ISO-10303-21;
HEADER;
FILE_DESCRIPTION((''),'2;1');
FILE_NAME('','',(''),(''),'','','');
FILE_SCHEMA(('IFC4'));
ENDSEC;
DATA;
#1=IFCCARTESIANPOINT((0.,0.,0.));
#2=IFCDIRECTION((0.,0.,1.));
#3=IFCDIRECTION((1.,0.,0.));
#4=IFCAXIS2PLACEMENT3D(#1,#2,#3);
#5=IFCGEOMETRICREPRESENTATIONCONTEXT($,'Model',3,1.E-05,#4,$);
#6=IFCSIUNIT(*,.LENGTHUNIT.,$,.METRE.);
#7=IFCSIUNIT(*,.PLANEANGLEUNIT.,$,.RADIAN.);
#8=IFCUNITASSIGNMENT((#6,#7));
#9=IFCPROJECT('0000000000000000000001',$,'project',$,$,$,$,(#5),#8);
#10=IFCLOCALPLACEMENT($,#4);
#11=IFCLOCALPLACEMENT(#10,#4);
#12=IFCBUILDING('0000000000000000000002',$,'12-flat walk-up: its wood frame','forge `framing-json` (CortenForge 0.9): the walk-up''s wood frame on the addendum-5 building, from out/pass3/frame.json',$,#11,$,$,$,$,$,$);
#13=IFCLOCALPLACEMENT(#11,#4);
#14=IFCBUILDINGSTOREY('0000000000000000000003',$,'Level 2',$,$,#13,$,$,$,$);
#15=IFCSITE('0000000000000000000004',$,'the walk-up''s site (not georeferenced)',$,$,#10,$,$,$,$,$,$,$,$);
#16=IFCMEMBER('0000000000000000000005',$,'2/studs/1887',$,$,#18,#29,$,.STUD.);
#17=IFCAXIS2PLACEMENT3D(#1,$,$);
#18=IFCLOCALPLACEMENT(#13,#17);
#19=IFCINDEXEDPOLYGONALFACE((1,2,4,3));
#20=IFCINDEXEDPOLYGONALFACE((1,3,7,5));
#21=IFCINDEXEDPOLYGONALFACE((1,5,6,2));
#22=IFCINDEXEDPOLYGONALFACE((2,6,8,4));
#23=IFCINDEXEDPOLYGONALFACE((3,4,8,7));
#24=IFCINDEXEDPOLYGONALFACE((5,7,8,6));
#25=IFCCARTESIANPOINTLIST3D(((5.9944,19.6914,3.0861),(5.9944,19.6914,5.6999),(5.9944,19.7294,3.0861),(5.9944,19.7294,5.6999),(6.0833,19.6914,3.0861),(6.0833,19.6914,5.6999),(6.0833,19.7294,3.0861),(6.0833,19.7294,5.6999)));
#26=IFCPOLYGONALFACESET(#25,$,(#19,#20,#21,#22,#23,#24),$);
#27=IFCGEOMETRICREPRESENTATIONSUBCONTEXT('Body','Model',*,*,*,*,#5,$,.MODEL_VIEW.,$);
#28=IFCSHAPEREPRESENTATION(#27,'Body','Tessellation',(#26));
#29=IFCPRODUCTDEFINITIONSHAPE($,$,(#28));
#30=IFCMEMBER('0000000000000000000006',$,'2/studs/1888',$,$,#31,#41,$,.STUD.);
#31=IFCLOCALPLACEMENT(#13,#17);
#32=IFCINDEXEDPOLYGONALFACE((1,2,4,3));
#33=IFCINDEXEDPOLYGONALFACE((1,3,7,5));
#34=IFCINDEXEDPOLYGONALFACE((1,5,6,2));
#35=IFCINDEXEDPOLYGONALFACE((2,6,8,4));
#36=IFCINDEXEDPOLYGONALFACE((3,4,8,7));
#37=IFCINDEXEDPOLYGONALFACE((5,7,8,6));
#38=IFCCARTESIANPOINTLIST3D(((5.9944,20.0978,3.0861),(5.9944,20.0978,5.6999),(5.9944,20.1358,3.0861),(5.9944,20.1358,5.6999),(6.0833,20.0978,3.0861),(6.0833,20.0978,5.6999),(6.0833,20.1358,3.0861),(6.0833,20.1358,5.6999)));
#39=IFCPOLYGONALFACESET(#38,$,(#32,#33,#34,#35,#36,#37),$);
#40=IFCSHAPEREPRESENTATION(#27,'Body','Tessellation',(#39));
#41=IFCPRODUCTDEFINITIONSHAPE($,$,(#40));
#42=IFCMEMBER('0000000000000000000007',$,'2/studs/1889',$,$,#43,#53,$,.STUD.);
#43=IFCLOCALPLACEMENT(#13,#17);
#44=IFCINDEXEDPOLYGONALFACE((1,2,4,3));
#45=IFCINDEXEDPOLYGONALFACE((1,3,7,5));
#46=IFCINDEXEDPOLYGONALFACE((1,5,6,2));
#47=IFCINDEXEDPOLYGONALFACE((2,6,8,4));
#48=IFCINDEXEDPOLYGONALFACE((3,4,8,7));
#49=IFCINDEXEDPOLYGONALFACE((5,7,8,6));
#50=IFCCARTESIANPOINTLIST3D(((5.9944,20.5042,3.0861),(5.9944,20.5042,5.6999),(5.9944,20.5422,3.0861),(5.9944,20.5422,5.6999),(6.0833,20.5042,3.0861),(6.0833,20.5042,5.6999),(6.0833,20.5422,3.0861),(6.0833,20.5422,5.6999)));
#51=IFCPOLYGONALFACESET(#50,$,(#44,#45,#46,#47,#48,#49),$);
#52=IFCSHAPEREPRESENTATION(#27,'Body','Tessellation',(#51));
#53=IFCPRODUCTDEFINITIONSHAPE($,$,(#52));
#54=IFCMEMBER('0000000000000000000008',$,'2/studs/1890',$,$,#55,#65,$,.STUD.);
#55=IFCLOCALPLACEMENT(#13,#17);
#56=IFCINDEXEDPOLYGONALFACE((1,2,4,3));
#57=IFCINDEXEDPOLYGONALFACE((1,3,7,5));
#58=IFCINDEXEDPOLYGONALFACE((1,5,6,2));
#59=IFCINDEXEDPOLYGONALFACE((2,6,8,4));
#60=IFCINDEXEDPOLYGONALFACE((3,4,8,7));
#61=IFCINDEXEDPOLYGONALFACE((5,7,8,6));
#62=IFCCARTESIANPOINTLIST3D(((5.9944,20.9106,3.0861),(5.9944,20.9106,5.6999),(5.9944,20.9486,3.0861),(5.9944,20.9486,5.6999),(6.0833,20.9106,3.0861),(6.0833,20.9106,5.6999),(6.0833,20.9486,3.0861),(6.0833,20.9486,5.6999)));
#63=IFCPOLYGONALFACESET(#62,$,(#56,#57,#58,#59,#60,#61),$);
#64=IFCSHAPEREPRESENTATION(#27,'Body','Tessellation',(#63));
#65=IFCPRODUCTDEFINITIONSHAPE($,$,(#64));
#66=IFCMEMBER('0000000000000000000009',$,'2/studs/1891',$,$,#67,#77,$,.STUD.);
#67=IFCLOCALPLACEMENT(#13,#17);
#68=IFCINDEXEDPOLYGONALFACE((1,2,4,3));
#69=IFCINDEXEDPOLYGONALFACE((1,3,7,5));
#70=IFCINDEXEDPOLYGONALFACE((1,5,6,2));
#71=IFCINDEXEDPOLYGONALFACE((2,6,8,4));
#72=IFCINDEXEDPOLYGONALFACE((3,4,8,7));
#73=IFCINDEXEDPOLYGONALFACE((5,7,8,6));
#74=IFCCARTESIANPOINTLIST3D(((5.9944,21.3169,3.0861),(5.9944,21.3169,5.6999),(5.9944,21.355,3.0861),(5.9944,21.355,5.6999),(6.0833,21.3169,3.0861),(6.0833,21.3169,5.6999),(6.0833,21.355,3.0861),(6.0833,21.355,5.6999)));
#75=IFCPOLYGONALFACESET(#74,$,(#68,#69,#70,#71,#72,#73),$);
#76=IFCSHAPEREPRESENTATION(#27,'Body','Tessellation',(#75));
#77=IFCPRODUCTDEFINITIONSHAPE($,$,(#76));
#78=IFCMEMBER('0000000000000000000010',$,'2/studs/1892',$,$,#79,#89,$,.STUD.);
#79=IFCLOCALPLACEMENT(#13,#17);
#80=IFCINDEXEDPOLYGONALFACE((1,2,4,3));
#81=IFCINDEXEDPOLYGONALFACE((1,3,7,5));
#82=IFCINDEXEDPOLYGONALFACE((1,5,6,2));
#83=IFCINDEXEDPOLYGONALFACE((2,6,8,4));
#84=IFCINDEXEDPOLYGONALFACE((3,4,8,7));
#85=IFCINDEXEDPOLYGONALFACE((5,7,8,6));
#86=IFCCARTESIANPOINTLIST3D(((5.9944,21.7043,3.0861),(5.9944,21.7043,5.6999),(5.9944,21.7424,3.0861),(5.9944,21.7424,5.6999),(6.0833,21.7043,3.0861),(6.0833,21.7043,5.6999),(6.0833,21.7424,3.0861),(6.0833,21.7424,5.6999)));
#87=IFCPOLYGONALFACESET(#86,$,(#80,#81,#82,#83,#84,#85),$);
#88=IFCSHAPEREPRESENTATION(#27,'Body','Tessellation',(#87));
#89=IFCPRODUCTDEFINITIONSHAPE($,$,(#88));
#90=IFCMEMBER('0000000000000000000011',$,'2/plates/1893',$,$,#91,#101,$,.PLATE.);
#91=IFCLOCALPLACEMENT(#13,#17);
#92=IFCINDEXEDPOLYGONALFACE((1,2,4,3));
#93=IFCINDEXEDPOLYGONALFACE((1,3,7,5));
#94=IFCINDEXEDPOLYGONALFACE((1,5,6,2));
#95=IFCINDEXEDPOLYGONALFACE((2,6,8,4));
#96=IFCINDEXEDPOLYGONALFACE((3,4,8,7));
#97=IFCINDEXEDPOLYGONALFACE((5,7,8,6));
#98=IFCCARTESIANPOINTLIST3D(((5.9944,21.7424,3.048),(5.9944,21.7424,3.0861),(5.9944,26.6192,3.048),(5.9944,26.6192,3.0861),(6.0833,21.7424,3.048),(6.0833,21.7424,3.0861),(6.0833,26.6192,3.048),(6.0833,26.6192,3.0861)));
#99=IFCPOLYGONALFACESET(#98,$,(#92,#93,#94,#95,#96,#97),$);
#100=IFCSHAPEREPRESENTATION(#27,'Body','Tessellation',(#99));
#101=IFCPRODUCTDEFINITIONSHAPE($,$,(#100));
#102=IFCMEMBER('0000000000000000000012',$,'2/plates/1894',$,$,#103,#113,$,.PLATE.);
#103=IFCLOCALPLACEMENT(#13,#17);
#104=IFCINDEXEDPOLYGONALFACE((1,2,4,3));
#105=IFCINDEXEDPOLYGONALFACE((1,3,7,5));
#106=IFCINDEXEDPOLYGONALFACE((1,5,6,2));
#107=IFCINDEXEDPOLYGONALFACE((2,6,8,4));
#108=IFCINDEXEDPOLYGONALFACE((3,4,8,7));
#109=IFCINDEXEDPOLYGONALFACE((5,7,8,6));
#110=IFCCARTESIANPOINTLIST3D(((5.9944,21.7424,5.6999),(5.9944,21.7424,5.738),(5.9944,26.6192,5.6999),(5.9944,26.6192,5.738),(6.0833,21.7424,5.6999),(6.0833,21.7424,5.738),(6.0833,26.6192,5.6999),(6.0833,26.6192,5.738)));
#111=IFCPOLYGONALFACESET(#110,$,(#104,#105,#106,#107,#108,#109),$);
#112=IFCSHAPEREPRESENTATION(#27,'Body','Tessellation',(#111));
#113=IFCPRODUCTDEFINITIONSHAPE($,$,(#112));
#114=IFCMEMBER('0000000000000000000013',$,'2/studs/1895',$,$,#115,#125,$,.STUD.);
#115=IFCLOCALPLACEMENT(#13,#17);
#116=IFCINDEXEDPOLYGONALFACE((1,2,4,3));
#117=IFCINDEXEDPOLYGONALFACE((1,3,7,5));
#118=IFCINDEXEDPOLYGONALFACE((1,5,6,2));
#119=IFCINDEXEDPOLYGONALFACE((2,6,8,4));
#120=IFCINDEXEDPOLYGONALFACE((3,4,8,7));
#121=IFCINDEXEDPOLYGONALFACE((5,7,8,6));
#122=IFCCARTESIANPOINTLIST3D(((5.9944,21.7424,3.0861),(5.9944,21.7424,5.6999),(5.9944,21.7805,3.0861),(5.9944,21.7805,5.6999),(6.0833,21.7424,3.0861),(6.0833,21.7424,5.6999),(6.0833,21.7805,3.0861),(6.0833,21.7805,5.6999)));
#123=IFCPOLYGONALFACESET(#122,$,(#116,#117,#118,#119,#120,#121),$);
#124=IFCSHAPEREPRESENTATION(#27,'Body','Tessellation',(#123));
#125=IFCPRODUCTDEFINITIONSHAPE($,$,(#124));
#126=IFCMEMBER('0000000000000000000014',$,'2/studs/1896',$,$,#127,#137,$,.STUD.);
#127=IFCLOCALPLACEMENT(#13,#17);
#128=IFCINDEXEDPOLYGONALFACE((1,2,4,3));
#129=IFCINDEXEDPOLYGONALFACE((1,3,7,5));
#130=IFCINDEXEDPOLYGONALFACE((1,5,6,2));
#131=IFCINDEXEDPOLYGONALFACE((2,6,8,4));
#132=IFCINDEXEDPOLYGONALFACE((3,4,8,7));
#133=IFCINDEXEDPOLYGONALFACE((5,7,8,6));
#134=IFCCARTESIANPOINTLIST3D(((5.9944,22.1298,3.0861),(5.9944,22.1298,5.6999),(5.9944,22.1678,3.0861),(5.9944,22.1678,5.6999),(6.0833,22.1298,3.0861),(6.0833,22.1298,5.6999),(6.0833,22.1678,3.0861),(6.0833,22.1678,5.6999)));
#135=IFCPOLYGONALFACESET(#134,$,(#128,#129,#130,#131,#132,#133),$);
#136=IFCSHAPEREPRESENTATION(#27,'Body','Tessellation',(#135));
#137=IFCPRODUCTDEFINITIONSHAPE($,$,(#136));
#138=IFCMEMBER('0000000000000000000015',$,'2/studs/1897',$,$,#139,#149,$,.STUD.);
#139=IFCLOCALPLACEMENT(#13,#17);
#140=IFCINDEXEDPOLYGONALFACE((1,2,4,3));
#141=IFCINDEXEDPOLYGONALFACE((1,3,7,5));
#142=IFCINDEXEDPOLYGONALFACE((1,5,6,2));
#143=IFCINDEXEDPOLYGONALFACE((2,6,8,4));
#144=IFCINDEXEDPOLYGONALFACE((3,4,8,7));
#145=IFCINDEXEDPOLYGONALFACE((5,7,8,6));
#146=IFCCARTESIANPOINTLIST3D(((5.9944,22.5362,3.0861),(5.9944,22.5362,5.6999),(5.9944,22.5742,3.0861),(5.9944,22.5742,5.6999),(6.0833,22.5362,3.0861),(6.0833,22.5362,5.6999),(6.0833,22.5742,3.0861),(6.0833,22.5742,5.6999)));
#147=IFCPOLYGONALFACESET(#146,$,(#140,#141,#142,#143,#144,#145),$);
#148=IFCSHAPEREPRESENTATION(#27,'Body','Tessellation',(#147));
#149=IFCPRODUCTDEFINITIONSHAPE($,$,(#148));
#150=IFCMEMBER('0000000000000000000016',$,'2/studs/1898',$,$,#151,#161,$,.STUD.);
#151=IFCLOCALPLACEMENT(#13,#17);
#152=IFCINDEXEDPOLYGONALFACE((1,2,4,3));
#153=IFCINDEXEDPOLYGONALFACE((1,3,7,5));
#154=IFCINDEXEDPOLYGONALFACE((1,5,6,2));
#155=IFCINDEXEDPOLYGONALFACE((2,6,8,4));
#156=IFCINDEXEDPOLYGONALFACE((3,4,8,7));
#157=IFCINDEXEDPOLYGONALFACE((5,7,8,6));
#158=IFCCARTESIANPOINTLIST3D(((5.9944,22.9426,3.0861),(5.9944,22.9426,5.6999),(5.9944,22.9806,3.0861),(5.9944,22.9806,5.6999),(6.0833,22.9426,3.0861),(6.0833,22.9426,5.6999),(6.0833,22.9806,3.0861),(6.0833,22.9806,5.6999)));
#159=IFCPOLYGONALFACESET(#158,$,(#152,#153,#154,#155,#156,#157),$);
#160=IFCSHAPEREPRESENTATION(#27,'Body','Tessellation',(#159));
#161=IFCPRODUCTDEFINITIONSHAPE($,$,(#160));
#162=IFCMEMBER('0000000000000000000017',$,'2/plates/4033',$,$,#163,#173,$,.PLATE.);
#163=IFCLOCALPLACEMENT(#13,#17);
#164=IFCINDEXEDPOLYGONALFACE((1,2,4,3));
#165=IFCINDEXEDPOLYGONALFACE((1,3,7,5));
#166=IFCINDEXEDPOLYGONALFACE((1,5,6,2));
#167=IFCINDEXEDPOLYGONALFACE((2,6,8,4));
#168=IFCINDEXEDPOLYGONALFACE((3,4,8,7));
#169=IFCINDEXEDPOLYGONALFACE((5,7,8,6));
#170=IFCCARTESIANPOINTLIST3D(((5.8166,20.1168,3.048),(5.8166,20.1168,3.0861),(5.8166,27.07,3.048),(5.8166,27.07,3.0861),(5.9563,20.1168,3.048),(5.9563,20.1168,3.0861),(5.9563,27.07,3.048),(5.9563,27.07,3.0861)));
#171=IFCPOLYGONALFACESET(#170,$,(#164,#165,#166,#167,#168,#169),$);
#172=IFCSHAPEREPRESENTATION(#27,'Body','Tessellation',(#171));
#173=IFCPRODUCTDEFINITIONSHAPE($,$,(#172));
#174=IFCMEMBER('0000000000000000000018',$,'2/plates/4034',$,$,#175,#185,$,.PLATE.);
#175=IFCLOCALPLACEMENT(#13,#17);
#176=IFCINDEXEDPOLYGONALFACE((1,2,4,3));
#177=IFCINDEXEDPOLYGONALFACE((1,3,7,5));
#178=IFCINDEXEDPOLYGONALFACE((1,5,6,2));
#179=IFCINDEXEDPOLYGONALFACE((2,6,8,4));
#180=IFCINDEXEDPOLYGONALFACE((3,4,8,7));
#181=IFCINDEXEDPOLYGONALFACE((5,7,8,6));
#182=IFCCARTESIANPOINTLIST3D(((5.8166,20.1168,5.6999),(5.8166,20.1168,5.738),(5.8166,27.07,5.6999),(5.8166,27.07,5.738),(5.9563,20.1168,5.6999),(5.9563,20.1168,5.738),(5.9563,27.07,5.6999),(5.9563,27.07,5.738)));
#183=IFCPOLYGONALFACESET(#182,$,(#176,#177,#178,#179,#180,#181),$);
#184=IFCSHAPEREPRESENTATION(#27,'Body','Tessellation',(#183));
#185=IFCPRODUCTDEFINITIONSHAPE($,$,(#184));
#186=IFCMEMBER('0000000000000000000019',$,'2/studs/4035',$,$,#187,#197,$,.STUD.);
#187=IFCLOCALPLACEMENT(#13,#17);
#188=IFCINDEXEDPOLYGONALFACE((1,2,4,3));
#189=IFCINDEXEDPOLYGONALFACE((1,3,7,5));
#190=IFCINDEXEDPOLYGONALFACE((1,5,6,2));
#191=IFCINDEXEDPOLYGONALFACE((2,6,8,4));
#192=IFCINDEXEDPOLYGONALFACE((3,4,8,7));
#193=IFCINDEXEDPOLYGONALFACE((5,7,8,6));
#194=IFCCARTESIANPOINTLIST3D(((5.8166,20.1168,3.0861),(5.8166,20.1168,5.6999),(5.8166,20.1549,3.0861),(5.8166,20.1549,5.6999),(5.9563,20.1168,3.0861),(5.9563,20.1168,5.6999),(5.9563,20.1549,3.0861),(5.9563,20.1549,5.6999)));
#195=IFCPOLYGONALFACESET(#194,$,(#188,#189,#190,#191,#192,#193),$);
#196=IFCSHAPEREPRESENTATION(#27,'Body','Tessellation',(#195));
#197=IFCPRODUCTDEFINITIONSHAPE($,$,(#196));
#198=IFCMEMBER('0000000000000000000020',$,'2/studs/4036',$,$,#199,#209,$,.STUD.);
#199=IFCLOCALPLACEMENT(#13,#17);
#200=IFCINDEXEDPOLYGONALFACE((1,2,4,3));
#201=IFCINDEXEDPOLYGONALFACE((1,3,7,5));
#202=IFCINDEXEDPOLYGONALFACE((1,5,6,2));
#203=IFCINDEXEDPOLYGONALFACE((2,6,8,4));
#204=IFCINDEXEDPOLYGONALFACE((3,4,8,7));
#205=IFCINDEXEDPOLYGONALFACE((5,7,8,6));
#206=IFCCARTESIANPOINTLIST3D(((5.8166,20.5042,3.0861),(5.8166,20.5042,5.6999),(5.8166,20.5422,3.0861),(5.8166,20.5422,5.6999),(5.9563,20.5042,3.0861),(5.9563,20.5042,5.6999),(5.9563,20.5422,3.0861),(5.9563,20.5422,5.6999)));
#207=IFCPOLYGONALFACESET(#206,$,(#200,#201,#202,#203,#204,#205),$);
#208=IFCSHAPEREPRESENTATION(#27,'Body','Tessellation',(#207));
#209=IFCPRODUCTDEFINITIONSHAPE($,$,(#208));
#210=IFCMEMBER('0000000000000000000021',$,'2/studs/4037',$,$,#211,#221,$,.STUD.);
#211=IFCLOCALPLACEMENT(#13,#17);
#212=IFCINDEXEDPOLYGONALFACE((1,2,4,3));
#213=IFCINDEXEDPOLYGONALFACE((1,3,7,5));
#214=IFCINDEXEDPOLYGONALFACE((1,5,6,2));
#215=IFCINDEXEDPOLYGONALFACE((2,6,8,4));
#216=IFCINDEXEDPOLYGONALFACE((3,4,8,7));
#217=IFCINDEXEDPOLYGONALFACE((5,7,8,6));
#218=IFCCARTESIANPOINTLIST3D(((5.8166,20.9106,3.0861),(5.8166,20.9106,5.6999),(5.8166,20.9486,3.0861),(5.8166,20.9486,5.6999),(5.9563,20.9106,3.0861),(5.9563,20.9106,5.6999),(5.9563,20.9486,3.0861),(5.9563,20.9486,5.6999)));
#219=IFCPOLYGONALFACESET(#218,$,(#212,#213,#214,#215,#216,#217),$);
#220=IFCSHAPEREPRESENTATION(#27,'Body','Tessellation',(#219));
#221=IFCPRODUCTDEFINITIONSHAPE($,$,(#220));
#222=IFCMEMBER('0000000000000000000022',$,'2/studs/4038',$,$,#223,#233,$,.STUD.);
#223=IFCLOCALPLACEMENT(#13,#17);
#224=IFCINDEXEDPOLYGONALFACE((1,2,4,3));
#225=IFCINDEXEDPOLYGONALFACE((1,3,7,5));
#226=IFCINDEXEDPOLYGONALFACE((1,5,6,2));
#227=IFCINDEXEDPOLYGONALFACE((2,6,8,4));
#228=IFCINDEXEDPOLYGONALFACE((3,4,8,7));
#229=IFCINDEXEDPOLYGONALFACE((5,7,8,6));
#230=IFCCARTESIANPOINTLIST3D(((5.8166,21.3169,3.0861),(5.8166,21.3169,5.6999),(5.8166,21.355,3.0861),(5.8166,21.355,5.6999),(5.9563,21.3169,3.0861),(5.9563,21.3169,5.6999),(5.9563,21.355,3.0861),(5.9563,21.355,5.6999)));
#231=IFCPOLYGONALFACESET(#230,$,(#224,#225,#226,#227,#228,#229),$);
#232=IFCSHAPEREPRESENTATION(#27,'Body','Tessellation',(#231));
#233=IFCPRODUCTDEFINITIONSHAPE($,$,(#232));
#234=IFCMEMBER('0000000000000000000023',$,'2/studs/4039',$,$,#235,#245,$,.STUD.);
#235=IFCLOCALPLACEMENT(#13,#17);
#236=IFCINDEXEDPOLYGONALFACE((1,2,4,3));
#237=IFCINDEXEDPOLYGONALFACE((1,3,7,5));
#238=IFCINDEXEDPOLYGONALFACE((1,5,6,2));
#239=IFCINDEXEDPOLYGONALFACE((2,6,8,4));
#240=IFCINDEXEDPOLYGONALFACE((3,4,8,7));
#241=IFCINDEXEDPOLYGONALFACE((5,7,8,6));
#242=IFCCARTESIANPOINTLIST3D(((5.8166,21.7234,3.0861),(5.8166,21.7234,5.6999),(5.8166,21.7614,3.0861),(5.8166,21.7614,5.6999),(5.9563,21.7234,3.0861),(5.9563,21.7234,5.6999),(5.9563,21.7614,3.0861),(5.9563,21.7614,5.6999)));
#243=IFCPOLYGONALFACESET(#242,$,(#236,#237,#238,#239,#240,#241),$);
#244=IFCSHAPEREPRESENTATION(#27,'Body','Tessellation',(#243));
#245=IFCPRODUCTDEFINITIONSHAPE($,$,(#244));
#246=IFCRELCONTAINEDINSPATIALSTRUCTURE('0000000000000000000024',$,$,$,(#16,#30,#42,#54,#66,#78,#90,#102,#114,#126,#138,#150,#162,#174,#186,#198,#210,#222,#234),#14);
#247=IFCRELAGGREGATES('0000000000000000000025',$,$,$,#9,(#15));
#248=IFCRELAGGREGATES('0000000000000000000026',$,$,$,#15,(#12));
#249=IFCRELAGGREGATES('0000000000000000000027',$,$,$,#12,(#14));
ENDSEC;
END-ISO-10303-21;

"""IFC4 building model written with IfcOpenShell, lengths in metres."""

from ifc_helpers import new_model, si_unit, frame, frame_2d, origin, origin_with_axes, place, context, subcontext, project, spatial, rectangle, extrude, element, save


model = new_model("IFC4")

# Units and contexts
model_context = context("Model", 3, precision=1e-05, world=origin_with_axes())
body_context = subcontext(model_context, "Body", "Model", "MODEL_VIEW")
ifc_project = project(units=[si_unit("LENGTHUNIT", "METRE"), si_unit("PLANEANGLEUNIT", "RADIAN")], contexts=[model_context])

# Site, building, storey
site_placement = place(None, origin_with_axes())
site = spatial("IfcSite", under=ifc_project, at=site_placement, Name="the walk-up's site (not georeferenced)")
building_placement = place(site_placement, origin_with_axes())
building = spatial("IfcBuilding", under=site, at=building_placement, Name="12-flat walk-up: its wood frame", Description="forge `framing-json` (CortenForge 0.9): the walk-up's wood frame on the addendum-5 building, from out/pass3/frame.json")
storey_placement = place(building_placement, origin_with_axes())
storey = spatial("IfcBuildingStorey", under=building, at=storey_placement, Name="Level 2")

# Members
for number, where, z_axis, x_axis, name in (
    (1, (5.9944, 19.6913, 3.0861), (0.0, 0.0, 1.0), (1.0, 0.0, 0.0), "2/studs/1887"),
    (2, (5.9944, 20.0978, 3.0861), (0.0, 0.0, 1.0), (1.0, 0.0, 0.0), "2/studs/1888"),
    (3, (5.9944, 20.5041, 3.0861), (0.0, 0.0, 1.0), (1.0, 0.0, 0.0), "2/studs/1889"),
    (4, (5.9944, 20.9106, 3.0861), (0.0, 0.0, 1.0), (1.0, 0.0, 0.0), "2/studs/1890"),
    (5, (5.9944, 21.3169, 3.0861), (0.0, 0.0, 1.0), (1.0, 0.0, 0.0), "2/studs/1891"),
    (6, (5.9944, 21.7043, 3.0861), (0.0, 0.0, 1.0), (1.0, 0.0, 0.0), "2/studs/1892"),
):
    element("IfcMember", number, at=place(storey_placement, frame(where, z_axis=z_axis, x_axis=x_axis)), inside=storey, Name=name, PredefinedType="STUD", context=body_context, shape_type="SweptSolid", body=[
        extrude(rectangle(XDim=0.0889, YDim=0.0381, at=frame_2d((0.0445, 0.0191))), origin(), (0.0, 0.0, 1.0), 2.6138),
    ])
for number, where, z_axis, x_axis, name in (
    (7, (5.9944, 21.7424, 3.048), (0.0, 0.0, 1.0), (1.0, 0.0, 0.0), "2/plates/1893"),
    (8, (5.9944, 21.7424, 5.6999), (0.0, 0.0, 1.0), (1.0, 0.0, 0.0), "2/plates/1894"),
):
    element("IfcMember", number, at=place(storey_placement, frame(where, z_axis=z_axis, x_axis=x_axis)), inside=storey, Name=name, PredefinedType="PLATE", context=body_context, shape_type="SweptSolid", body=[
        extrude(rectangle(XDim=0.0889, YDim=4.8768, at=frame_2d((0.0445, 2.4384))), origin(), (0.0, 0.0, 1.0), 0.0381),
    ])
for number, where, z_axis, x_axis, name in (
    (9, (5.9944, 21.7424, 3.0861), (0.0, 0.0, 1.0), (1.0, 0.0, 0.0), "2/studs/1895"),
    (10, (5.9944, 22.1298, 3.0861), (0.0, 0.0, 1.0), (1.0, 0.0, 0.0), "2/studs/1896"),
    (11, (5.9944, 22.5361, 3.0861), (0.0, 0.0, 1.0), (1.0, 0.0, 0.0), "2/studs/1897"),
    (12, (5.9944, 22.9426, 3.0861), (0.0, 0.0, 1.0), (1.0, 0.0, 0.0), "2/studs/1898"),
):
    element("IfcMember", number, at=place(storey_placement, frame(where, z_axis=z_axis, x_axis=x_axis)), inside=storey, Name=name, PredefinedType="STUD", context=body_context, shape_type="SweptSolid", body=[
        extrude(rectangle(XDim=0.0889, YDim=0.0381, at=frame_2d((0.0445, 0.0191))), origin(), (0.0, 0.0, 1.0), 2.6138),
    ])
for number, where, z_axis, x_axis, name in (
    (13, (5.8166, 20.1168, 3.048), (0.0, 0.0, 1.0), (1.0, 0.0, 0.0), "2/plates/4033"),
    (14, (5.8166, 20.1168, 5.6999), (0.0, 0.0, 1.0), (1.0, 0.0, 0.0), "2/plates/4034"),
):
    element("IfcMember", number, at=place(storey_placement, frame(where, z_axis=z_axis, x_axis=x_axis)), inside=storey, Name=name, PredefinedType="PLATE", context=body_context, shape_type="SweptSolid", body=[
        extrude(rectangle(XDim=0.1397, YDim=6.9532, at=frame_2d((0.0698, 3.4766))), origin(), (0.0, 0.0, 1.0), 0.0381),
    ])
for number, where, z_axis, x_axis, name in (
    (15, (5.8166, 20.1168, 3.0861), (0.0, 0.0, 1.0), (1.0, 0.0, 0.0), "2/studs/4035"),
    (16, (5.8166, 20.5041, 3.0861), (0.0, 0.0, 1.0), (1.0, 0.0, 0.0), "2/studs/4036"),
    (17, (5.8166, 20.9106, 3.0861), (0.0, 0.0, 1.0), (1.0, 0.0, 0.0), "2/studs/4037"),
    (18, (5.8166, 21.3169, 3.0861), (0.0, 0.0, 1.0), (1.0, 0.0, 0.0), "2/studs/4038"),
    (19, (5.8166, 21.7233, 3.0861), (0.0, 0.0, 1.0), (1.0, 0.0, 0.0), "2/studs/4039"),
):
    element("IfcMember", number, at=place(storey_placement, frame(where, z_axis=z_axis, x_axis=x_axis)), inside=storey, Name=name, PredefinedType="STUD", context=body_context, shape_type="SweptSolid", body=[
        extrude(rectangle(XDim=0.1397, YDim=0.0381, at=frame_2d((0.0698, 0.0191))), origin(), (0.0, 0.0, 1.0), 2.6138),
    ])

save(model, "model.ifc")
